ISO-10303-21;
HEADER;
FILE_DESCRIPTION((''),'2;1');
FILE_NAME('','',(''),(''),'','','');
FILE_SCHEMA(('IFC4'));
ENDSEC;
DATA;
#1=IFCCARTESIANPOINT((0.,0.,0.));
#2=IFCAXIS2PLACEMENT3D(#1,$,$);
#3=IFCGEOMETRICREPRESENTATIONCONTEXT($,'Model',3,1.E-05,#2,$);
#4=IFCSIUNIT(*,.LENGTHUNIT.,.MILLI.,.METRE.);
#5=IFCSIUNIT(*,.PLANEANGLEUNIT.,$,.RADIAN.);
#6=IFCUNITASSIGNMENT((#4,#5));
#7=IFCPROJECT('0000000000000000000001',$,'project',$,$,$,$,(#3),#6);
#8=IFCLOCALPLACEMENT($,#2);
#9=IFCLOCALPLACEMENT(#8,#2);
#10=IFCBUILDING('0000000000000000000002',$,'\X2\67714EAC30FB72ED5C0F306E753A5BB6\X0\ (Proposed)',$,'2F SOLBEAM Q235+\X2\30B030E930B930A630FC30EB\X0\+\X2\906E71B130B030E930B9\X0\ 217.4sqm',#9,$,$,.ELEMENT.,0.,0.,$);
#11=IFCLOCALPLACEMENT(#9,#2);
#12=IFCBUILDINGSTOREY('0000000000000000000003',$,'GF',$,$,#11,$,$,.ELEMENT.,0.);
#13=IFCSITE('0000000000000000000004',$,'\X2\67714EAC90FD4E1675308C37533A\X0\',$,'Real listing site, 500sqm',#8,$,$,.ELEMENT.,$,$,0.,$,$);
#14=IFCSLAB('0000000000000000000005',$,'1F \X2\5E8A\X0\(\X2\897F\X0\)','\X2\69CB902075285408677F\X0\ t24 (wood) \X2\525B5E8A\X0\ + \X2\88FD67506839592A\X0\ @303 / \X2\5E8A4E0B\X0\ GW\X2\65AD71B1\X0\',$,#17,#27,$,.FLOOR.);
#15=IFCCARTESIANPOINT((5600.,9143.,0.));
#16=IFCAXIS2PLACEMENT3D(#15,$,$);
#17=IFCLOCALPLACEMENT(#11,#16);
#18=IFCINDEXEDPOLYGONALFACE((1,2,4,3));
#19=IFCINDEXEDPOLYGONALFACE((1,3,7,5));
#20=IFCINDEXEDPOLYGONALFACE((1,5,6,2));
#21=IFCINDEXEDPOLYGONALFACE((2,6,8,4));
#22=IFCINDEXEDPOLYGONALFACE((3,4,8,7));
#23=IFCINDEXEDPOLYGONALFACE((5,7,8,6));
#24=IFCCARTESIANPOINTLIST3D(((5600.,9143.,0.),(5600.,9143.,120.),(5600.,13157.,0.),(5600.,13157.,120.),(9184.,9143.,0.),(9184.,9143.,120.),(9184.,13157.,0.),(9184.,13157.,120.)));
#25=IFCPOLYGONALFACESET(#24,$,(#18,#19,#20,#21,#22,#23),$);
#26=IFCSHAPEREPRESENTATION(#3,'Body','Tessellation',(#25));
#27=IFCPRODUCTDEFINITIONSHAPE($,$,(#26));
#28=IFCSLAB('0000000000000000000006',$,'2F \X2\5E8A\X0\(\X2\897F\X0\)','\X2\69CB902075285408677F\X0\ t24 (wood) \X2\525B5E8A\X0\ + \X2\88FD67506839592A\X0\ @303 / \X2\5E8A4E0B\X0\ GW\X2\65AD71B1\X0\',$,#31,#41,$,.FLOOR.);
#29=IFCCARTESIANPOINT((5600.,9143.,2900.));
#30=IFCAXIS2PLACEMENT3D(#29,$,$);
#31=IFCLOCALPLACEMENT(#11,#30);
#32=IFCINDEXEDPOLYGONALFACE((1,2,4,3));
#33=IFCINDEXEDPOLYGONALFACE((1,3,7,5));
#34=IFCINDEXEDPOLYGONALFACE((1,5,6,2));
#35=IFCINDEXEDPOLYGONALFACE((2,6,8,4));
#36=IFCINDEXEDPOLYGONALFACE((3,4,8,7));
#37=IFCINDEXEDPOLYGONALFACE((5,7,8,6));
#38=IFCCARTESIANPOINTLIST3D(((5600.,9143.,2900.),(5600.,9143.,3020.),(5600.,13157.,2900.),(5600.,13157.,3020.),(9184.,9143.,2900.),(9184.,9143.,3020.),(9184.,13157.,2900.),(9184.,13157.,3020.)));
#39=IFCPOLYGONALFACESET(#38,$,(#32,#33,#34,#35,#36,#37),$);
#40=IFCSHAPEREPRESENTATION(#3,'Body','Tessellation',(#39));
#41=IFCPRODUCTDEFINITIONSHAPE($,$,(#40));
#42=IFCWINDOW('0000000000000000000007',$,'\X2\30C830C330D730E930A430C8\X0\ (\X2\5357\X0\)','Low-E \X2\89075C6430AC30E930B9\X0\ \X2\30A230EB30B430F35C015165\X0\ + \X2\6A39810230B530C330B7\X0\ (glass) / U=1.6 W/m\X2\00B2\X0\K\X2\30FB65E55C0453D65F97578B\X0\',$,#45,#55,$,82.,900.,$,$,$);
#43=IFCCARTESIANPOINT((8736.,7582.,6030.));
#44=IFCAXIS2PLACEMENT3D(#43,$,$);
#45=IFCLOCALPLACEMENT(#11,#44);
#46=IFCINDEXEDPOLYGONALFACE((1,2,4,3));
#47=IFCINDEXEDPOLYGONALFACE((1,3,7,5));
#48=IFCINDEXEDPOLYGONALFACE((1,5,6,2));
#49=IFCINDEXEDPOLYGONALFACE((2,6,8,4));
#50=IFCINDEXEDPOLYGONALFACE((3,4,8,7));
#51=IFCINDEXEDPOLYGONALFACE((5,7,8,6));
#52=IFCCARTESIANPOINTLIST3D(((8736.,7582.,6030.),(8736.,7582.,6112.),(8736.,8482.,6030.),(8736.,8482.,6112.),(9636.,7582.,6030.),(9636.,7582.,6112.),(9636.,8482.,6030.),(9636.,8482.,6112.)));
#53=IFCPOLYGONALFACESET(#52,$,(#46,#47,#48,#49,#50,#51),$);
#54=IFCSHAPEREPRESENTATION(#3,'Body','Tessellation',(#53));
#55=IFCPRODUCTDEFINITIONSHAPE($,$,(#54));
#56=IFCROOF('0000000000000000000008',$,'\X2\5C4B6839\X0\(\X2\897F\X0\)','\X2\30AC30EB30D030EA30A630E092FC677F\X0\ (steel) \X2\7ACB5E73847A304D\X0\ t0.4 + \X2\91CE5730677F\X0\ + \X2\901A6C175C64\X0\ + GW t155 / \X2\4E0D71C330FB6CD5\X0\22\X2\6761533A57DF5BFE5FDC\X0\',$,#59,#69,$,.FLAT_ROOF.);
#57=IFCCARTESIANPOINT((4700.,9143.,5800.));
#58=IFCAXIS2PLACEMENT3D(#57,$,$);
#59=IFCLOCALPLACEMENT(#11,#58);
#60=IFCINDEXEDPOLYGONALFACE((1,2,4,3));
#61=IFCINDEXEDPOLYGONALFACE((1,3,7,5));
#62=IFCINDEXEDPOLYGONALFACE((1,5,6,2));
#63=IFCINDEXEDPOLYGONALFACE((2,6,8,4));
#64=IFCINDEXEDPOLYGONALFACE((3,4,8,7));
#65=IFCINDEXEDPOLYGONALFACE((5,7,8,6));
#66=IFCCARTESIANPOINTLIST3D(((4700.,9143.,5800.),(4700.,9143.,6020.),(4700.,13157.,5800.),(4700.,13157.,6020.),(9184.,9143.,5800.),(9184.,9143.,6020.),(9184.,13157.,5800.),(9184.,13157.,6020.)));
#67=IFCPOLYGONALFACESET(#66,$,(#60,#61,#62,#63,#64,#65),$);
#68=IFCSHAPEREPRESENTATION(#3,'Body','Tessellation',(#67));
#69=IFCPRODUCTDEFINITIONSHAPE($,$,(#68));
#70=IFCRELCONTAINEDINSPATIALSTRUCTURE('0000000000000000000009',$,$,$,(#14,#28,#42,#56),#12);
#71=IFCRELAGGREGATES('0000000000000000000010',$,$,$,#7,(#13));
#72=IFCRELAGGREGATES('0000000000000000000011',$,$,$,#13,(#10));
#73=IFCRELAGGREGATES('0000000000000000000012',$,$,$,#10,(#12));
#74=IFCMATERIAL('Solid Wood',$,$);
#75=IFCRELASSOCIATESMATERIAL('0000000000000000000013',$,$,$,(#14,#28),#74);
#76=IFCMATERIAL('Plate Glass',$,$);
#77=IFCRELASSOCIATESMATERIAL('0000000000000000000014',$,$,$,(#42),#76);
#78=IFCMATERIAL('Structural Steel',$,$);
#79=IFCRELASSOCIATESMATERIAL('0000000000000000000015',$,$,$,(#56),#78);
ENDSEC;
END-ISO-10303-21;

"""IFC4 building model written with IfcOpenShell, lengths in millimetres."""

from ifc_helpers import new_model, si_unit, frame, frame_2d, origin, place, context, project, spatial, rectangle, extrude, material, element, save


model = new_model("IFC4")

# Units and contexts
model_context = context("Model", 3, precision=1e-05, world=origin())
ifc_project = project(units=[si_unit("LENGTHUNIT", "METRE", prefix="MILLI"), si_unit("PLANEANGLEUNIT", "RADIAN")], contexts=[model_context])

# Site, building, storey
site_placement = place(None, origin())
site = spatial("IfcSite", under=ifc_project, at=site_placement, Name="東京都世田谷区", ObjectType="Real listing site, 500sqm", CompositionType="ELEMENT", RefElevation=0.0)
building_placement = place(site_placement, origin())
building = spatial("IfcBuilding", under=site, at=building_placement, Name="東京・狭小の町家 (Proposed)", ObjectType="2F SOLBEAM Q235+グラスウール+遮熱グラス 217.4sqm", CompositionType="ELEMENT", ElevationOfRefHeight=0.0, ElevationOfTerrain=0.0)
storey_placement = place(building_placement, origin())
storey = spatial("IfcBuildingStorey", under=building, at=storey_placement, Name="GF", CompositionType="ELEMENT", Elevation=0.0)

# Shared definitions
ifc_material_1 = material(Name="Solid Wood")

# Slabs
slab_1_placement = place(storey_placement, frame((5600.0, 9143.0, 0.0)))
element("IfcSlab", 1, at=slab_1_placement, inside=storey, material=ifc_material_1, Name="1F 床(西)", Description="構造用合板 t24 (wood) 剛床 + 製材根太 @303 / 床下 GW断熱", PredefinedType="FLOOR", context=model_context, shape_type="SweptSolid", body=[
    extrude(rectangle(XDim=3584.0, YDim=4014.0, at=frame_2d((1792.0, 2007.0))), frame((5600.0, 9143.0, 0.0)), (0.0, 0.0, 1.0), 120.0),
])
slab_2_placement = place(storey_placement, frame((5600.0, 9143.0, 2900.0)))
element("IfcSlab", 2, at=slab_2_placement, inside=storey, material=ifc_material_1, Name="2F 床(西)", Description="構造用合板 t24 (wood) 剛床 + 製材根太 @303 / 床下 GW断熱", PredefinedType="FLOOR", context=model_context, shape_type="SweptSolid", body=[
    extrude(rectangle(XDim=3584.0, YDim=4014.0, at=frame_2d((1792.0, 2007.0))), frame((5600.0, 9143.0, 2900.0)), (0.0, 0.0, 1.0), 120.0),
])

# Window
ifc_material_2 = material(Name="Plate Glass")
window_placement = place(storey_placement, frame((8736.0, 7582.0, 6030.0)))
element("IfcWindow", 3, at=window_placement, inside=storey, material=ifc_material_2, Name="トップライト (南)", Description="Low-E 複層ガラス アルゴン封入 + 樹脂サッシ (glass) / U=1.6 W/m²K・日射取得型", OverallHeight=82.0, OverallWidth=900.0, context=model_context, shape_type="SweptSolid", body=[
    extrude(rectangle(XDim=900.0, YDim=900.0, at=frame_2d((450.0, 450.0))), frame((8736.0, 7582.0, 6030.0)), (0.0, 0.0, 1.0), 82.0),
])

# Roof
ifc_material_3 = material(Name="Structural Steel")
for number, where, name in (
    (4, (4700.0, 9143.0, 5800.0), "屋根(西)"),
):
    element("IfcRoof", number, at=place(storey_placement, frame(where)), inside=storey, material=ifc_material_3, Name=name, Description="ガルバリウム鋼板 (steel) 立平葺き t0.4 + 野地板 + 通気層 + GW t155 / 不燃・法22条区域対応", PredefinedType="FLAT_ROOF", context=model_context, shape_type="SweptSolid", body=[
        extrude(rectangle(XDim=4484.0, YDim=4014.0, at=frame_2d((2242.0, 2007.0))), frame((4700.0, 9143.0, 5800.0)), (0.0, 0.0, 1.0), 220.0),
    ])

save(model, "model.ifc")
